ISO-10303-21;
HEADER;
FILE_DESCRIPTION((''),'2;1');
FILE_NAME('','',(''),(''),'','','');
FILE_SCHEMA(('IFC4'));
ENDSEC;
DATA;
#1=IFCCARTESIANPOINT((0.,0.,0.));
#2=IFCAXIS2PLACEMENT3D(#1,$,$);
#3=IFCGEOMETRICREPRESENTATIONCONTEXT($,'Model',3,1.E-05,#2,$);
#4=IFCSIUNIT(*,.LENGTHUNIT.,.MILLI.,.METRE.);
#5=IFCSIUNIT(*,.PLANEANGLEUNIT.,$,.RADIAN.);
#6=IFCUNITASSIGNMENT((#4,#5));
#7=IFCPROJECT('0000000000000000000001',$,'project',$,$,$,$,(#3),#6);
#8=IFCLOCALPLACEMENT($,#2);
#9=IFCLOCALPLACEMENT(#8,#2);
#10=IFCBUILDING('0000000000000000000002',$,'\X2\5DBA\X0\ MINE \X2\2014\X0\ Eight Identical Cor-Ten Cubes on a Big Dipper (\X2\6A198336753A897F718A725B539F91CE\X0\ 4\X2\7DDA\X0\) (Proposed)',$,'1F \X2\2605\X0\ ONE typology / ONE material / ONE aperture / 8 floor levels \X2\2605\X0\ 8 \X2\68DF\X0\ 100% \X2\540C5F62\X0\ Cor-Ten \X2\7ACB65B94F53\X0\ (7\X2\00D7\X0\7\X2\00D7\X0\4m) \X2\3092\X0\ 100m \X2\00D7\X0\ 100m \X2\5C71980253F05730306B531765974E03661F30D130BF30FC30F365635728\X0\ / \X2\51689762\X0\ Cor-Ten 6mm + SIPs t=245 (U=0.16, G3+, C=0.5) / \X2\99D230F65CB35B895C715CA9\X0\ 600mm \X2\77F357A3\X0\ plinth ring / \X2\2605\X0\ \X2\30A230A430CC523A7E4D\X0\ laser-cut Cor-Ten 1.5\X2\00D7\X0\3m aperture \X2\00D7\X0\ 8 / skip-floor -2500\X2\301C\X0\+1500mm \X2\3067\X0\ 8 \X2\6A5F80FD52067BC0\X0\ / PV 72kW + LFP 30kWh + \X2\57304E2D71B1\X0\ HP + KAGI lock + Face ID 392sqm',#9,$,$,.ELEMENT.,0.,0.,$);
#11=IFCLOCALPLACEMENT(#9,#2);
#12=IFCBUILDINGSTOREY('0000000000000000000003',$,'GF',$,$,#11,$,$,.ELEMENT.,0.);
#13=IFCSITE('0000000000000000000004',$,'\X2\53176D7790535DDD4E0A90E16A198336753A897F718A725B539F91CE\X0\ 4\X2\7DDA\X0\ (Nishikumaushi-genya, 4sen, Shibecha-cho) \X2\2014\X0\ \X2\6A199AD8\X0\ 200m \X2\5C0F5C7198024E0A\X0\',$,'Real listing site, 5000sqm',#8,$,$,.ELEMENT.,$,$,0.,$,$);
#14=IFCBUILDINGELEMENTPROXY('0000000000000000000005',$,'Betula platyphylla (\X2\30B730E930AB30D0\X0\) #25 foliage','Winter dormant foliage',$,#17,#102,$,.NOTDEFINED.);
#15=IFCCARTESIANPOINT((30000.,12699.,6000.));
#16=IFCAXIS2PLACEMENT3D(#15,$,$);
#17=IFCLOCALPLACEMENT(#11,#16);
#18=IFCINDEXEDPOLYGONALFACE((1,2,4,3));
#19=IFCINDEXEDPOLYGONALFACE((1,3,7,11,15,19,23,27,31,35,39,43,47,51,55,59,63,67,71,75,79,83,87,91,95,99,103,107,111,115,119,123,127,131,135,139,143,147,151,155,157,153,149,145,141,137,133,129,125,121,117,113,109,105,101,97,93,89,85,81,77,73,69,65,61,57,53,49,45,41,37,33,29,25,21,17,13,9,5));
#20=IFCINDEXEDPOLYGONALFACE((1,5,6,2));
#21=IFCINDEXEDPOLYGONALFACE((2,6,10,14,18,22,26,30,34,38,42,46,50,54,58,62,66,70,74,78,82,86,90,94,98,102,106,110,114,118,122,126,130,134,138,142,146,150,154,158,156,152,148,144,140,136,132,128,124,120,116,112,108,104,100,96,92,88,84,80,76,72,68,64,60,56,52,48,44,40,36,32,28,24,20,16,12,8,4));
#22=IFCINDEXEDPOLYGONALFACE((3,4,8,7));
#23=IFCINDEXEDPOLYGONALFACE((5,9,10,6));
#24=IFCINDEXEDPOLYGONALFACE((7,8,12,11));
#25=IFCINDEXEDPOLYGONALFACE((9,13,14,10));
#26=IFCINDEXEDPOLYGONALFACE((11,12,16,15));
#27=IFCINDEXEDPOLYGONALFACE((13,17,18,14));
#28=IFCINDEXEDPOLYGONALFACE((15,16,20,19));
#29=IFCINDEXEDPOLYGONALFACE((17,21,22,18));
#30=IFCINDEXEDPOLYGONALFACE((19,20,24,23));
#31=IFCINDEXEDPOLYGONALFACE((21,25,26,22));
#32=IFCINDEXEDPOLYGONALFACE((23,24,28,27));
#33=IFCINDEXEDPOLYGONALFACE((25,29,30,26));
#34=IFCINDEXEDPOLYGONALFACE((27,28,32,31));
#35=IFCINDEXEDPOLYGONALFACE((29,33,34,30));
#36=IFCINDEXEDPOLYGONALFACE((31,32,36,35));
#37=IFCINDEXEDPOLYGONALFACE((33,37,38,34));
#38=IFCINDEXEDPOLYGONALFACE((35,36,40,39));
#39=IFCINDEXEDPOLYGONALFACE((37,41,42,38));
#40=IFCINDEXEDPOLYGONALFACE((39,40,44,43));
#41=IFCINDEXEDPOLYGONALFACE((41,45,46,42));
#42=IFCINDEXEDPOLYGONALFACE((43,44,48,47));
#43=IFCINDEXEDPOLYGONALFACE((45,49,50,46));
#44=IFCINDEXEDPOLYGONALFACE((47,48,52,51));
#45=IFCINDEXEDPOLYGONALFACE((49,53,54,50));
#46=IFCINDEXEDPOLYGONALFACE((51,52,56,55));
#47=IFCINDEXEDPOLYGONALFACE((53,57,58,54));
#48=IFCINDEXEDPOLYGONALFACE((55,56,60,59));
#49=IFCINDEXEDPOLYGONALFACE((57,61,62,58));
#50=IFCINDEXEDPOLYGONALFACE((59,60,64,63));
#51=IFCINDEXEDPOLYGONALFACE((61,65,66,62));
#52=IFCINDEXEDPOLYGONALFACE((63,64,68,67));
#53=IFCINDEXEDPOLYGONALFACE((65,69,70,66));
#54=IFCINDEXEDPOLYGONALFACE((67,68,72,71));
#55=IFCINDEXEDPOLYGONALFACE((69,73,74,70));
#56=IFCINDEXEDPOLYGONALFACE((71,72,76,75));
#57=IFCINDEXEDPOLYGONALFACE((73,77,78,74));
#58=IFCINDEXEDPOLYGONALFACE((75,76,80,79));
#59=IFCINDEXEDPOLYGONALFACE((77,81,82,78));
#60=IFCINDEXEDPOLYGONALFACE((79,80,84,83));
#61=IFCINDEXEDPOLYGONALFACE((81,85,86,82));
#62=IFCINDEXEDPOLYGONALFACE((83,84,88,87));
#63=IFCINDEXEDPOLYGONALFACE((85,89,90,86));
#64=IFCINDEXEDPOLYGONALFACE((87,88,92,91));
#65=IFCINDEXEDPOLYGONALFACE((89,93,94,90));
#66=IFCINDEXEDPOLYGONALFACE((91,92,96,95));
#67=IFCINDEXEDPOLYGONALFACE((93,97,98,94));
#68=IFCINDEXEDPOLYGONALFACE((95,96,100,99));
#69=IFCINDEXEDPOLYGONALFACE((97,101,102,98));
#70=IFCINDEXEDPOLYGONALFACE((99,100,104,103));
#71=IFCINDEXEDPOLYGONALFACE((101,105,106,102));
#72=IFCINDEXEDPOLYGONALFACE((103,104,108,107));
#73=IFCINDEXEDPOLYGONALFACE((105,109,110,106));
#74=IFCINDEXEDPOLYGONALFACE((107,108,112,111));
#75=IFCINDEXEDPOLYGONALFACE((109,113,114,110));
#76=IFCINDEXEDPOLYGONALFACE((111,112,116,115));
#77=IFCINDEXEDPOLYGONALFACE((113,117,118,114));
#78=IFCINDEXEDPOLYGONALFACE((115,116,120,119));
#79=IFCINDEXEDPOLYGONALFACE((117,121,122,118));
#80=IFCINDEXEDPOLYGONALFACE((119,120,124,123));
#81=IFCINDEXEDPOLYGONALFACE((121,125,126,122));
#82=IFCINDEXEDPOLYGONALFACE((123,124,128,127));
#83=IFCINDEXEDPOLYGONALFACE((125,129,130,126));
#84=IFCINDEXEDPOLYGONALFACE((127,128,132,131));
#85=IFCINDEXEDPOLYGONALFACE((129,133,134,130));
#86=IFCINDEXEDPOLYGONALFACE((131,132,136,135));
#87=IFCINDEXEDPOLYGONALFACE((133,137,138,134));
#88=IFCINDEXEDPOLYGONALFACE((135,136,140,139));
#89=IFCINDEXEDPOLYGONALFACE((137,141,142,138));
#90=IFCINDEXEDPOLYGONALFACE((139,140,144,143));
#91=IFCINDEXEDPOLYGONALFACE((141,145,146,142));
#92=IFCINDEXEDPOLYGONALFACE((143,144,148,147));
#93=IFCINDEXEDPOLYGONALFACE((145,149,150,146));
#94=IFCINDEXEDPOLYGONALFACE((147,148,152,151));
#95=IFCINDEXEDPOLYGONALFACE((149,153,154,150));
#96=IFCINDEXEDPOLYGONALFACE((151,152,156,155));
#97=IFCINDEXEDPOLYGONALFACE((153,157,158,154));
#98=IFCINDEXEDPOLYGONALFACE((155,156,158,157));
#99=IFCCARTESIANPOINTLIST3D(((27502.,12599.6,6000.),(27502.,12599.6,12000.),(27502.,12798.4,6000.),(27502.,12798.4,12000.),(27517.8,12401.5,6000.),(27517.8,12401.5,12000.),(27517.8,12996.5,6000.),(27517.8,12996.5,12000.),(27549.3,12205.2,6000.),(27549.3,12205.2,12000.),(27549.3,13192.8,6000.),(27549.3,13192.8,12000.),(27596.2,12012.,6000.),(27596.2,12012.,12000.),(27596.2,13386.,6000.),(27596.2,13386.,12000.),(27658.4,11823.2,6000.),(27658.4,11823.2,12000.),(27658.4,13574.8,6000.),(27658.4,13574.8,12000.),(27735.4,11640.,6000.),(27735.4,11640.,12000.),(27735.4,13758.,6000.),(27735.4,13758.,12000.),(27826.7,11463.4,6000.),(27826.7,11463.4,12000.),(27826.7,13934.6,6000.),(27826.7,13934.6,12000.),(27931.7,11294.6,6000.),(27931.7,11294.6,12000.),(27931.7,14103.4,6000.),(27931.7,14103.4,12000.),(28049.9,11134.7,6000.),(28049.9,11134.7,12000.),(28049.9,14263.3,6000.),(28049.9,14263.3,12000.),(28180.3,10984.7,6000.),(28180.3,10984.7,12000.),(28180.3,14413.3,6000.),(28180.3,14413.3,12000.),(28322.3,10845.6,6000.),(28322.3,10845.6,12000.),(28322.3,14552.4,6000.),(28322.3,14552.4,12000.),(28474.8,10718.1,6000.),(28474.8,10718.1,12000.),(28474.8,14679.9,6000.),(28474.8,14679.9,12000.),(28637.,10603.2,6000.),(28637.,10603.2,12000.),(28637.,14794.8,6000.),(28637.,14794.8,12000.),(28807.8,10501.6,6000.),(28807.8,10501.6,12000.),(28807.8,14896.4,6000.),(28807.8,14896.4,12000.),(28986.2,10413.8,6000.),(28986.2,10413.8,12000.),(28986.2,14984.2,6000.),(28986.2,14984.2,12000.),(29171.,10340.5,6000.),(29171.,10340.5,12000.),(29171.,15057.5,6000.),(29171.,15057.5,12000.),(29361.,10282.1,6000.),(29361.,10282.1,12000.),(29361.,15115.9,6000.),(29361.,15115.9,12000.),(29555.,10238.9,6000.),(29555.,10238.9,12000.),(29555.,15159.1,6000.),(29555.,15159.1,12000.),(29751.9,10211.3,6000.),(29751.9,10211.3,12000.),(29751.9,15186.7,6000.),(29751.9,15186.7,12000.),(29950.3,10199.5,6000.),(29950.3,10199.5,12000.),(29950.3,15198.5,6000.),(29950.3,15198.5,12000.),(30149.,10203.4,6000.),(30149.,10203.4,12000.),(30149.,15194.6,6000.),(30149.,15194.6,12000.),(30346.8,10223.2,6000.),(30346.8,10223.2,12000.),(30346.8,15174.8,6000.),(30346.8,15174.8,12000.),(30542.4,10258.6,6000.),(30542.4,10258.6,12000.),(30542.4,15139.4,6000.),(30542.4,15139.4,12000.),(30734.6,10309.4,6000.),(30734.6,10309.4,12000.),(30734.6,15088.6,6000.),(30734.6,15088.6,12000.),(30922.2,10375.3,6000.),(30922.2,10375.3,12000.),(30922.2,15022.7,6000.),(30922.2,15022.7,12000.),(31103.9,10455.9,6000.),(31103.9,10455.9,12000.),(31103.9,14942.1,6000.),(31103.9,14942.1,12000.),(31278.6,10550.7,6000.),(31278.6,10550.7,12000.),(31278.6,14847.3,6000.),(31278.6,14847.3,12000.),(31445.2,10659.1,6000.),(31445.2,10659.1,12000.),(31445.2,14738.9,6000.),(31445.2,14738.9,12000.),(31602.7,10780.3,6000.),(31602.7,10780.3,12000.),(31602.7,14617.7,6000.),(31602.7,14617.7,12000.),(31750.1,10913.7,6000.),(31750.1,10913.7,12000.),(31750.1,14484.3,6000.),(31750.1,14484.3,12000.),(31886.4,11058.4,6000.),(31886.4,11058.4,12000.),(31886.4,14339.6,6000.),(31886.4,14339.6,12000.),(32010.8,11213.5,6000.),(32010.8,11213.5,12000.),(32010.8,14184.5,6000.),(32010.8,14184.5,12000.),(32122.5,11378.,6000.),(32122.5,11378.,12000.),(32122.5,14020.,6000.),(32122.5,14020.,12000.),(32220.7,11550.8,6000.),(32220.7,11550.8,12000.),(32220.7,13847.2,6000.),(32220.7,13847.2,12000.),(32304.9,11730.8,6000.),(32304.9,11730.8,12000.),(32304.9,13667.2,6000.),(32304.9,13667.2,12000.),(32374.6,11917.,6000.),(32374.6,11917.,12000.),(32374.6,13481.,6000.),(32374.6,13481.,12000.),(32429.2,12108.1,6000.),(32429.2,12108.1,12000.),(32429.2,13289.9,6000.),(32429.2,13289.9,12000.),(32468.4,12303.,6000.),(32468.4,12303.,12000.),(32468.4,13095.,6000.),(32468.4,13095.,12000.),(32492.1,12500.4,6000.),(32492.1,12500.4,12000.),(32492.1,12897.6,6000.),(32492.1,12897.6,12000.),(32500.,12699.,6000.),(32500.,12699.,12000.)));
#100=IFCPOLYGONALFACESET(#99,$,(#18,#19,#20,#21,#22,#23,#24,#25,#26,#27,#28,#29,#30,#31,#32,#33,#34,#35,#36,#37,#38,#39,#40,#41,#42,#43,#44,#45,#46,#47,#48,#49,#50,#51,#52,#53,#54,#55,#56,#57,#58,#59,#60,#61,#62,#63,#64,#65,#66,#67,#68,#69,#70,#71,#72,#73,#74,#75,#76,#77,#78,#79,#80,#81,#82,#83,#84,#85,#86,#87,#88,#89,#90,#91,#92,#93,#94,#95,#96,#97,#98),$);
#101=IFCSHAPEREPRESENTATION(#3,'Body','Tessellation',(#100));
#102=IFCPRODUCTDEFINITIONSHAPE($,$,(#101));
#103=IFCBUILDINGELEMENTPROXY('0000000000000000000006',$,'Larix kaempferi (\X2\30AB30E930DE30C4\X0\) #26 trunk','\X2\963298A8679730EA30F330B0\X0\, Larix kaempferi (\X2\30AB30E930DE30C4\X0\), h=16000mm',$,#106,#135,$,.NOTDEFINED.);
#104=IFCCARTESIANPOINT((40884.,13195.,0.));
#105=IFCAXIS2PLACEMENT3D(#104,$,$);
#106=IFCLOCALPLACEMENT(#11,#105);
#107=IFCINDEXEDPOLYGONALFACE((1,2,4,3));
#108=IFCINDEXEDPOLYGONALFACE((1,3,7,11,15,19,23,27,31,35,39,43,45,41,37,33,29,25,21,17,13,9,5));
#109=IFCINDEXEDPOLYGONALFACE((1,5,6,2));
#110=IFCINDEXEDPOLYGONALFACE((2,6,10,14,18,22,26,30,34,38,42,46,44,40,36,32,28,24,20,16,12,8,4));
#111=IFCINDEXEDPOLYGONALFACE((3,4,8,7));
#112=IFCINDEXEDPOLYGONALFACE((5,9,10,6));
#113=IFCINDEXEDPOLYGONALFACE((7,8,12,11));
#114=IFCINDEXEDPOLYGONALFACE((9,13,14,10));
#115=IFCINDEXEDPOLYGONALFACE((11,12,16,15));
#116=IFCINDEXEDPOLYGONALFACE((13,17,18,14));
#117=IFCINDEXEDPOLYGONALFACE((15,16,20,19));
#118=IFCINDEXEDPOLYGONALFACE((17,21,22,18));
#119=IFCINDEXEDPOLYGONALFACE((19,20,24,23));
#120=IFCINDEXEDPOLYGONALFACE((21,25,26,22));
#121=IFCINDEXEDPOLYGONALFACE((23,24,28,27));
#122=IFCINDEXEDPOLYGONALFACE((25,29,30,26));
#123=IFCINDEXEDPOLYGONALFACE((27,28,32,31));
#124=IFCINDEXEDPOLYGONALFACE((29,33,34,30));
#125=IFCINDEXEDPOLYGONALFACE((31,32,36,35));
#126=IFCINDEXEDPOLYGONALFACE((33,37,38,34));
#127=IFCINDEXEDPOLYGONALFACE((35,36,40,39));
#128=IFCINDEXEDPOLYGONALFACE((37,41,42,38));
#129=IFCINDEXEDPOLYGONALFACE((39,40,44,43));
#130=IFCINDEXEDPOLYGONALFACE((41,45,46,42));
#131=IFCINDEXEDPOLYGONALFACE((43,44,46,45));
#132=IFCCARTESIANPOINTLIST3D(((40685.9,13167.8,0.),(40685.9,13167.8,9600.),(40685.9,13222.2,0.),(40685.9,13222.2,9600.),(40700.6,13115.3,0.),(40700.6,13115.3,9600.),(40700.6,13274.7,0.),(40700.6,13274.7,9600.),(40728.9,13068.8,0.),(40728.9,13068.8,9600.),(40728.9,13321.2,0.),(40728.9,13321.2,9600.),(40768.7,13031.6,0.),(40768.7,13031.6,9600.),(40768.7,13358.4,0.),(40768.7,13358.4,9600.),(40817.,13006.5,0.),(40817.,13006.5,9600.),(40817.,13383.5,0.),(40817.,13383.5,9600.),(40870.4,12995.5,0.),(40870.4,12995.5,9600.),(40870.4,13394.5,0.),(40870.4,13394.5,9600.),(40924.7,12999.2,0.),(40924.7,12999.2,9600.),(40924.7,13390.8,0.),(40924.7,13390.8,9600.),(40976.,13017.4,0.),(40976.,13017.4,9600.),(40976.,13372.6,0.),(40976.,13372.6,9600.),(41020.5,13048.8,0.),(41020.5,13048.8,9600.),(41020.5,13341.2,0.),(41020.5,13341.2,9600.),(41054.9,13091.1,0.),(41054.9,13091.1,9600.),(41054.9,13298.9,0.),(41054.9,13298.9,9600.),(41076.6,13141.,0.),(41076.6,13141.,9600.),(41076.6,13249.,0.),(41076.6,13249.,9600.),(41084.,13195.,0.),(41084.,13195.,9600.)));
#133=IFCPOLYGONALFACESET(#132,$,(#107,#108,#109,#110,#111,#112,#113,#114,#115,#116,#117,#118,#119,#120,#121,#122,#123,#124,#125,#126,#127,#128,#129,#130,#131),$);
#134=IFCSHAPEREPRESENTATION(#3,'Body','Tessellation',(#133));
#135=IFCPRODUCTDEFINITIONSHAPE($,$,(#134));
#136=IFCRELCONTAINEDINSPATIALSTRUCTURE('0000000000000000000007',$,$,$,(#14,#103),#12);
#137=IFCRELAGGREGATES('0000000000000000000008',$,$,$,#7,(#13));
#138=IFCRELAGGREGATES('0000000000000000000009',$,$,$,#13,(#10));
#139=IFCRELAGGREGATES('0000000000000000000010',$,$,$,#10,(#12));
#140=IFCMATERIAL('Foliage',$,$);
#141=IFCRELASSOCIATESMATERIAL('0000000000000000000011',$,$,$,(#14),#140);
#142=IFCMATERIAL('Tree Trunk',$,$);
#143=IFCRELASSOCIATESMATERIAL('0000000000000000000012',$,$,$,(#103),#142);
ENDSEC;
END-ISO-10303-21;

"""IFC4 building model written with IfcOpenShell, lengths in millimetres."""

from ifc_helpers import new_model, si_unit, frame, origin, origin_2d, place, context, project, spatial, circle, extrude, material, element, save


model = new_model("IFC4")

# Units and contexts
model_context = context("Model", 3, precision=1e-05, world=origin())
ifc_project = project(units=[si_unit("LENGTHUNIT", "METRE", prefix="MILLI"), si_unit("PLANEANGLEUNIT", "RADIAN")], contexts=[model_context])

# Site, building, storey
site_placement = place(None, origin())
site = spatial("IfcSite", under=ifc_project, at=site_placement, Name="北海道川上郡標茶町西熊牛原野 4線 (Nishikumaushi-genya, 4sen, Shibecha-cho) — 標高 200m 小山頂上", ObjectType="Real listing site, 5000sqm", CompositionType="ELEMENT", RefElevation=0.0)
building_placement = place(site_placement, origin())
building = spatial("IfcBuilding", under=site, at=building_placement, Name="嶺 MINE — Eight Identical Cor-Ten Cubes on a Big Dipper (標茶町西熊牛原野 4線) (Proposed)", ObjectType="1F ★ ONE typology / ONE material / ONE aperture / 8 floor levels ★ 8 棟 100% 同形 Cor-Ten 立方体 (7×7×4m) を 100m × 100m 山頂台地に北斗七星パターン散在 / 全面 Cor-Ten 6mm + SIPs t=245 (U=0.16, G3+, C=0.5) / 駒ヶ岳安山岩 600mm 石垣 plinth ring / ★ アイヌ刺繍 laser-cut Cor-Ten 1.5×3m aperture × 8 / skip-floor -2500〜+1500mm で 8 機能分節 / PV 72kW + LFP 30kWh + 地中熱 HP + KAGI lock + Face ID 392sqm", CompositionType="ELEMENT", ElevationOfRefHeight=0.0, ElevationOfTerrain=0.0)
storey_placement = place(building_placement, origin())
storey = spatial("IfcBuildingStorey", under=building, at=storey_placement, Name="GF", CompositionType="ELEMENT", Elevation=0.0)

# Building element proxies
ifc_material_1 = material(Name="Tree Trunk")
ifc_material_2 = material(Name="Foliage")
proxy_1_placement = place(storey_placement, frame((30000.0, 12699.0, 6000.0)))
element("IfcBuildingElementProxy", 1, at=proxy_1_placement, inside=storey, material=ifc_material_2, Name="Betula platyphylla (シラカバ) #25 foliage", Description="Winter dormant foliage", PredefinedType="NOTDEFINED", context=model_context, shape_type="SweptSolid", body=[
    extrude(circle(Radius=2500.0, at=origin_2d()), frame((30000.0, 12699.0, 6000.0)), (0.0, 0.0, 1.0), 6000.0),
])
proxy_2_placement = place(storey_placement, frame((40884.0, 13195.0, 0.0)))
element("IfcBuildingElementProxy", 2, at=proxy_2_placement, inside=storey, material=ifc_material_1, Name="Larix kaempferi (カラマツ) #26 trunk", Description="防風林リング, Larix kaempferi (カラマツ), h=16000mm", PredefinedType="NOTDEFINED", context=model_context, shape_type="SweptSolid", body=[
    extrude(circle(Radius=200.0, at=origin_2d()), frame((40884.0, 13195.0, 0.0)), (0.0, 0.0, 1.0), 9600.0),
])

save(model, "model.ifc")
